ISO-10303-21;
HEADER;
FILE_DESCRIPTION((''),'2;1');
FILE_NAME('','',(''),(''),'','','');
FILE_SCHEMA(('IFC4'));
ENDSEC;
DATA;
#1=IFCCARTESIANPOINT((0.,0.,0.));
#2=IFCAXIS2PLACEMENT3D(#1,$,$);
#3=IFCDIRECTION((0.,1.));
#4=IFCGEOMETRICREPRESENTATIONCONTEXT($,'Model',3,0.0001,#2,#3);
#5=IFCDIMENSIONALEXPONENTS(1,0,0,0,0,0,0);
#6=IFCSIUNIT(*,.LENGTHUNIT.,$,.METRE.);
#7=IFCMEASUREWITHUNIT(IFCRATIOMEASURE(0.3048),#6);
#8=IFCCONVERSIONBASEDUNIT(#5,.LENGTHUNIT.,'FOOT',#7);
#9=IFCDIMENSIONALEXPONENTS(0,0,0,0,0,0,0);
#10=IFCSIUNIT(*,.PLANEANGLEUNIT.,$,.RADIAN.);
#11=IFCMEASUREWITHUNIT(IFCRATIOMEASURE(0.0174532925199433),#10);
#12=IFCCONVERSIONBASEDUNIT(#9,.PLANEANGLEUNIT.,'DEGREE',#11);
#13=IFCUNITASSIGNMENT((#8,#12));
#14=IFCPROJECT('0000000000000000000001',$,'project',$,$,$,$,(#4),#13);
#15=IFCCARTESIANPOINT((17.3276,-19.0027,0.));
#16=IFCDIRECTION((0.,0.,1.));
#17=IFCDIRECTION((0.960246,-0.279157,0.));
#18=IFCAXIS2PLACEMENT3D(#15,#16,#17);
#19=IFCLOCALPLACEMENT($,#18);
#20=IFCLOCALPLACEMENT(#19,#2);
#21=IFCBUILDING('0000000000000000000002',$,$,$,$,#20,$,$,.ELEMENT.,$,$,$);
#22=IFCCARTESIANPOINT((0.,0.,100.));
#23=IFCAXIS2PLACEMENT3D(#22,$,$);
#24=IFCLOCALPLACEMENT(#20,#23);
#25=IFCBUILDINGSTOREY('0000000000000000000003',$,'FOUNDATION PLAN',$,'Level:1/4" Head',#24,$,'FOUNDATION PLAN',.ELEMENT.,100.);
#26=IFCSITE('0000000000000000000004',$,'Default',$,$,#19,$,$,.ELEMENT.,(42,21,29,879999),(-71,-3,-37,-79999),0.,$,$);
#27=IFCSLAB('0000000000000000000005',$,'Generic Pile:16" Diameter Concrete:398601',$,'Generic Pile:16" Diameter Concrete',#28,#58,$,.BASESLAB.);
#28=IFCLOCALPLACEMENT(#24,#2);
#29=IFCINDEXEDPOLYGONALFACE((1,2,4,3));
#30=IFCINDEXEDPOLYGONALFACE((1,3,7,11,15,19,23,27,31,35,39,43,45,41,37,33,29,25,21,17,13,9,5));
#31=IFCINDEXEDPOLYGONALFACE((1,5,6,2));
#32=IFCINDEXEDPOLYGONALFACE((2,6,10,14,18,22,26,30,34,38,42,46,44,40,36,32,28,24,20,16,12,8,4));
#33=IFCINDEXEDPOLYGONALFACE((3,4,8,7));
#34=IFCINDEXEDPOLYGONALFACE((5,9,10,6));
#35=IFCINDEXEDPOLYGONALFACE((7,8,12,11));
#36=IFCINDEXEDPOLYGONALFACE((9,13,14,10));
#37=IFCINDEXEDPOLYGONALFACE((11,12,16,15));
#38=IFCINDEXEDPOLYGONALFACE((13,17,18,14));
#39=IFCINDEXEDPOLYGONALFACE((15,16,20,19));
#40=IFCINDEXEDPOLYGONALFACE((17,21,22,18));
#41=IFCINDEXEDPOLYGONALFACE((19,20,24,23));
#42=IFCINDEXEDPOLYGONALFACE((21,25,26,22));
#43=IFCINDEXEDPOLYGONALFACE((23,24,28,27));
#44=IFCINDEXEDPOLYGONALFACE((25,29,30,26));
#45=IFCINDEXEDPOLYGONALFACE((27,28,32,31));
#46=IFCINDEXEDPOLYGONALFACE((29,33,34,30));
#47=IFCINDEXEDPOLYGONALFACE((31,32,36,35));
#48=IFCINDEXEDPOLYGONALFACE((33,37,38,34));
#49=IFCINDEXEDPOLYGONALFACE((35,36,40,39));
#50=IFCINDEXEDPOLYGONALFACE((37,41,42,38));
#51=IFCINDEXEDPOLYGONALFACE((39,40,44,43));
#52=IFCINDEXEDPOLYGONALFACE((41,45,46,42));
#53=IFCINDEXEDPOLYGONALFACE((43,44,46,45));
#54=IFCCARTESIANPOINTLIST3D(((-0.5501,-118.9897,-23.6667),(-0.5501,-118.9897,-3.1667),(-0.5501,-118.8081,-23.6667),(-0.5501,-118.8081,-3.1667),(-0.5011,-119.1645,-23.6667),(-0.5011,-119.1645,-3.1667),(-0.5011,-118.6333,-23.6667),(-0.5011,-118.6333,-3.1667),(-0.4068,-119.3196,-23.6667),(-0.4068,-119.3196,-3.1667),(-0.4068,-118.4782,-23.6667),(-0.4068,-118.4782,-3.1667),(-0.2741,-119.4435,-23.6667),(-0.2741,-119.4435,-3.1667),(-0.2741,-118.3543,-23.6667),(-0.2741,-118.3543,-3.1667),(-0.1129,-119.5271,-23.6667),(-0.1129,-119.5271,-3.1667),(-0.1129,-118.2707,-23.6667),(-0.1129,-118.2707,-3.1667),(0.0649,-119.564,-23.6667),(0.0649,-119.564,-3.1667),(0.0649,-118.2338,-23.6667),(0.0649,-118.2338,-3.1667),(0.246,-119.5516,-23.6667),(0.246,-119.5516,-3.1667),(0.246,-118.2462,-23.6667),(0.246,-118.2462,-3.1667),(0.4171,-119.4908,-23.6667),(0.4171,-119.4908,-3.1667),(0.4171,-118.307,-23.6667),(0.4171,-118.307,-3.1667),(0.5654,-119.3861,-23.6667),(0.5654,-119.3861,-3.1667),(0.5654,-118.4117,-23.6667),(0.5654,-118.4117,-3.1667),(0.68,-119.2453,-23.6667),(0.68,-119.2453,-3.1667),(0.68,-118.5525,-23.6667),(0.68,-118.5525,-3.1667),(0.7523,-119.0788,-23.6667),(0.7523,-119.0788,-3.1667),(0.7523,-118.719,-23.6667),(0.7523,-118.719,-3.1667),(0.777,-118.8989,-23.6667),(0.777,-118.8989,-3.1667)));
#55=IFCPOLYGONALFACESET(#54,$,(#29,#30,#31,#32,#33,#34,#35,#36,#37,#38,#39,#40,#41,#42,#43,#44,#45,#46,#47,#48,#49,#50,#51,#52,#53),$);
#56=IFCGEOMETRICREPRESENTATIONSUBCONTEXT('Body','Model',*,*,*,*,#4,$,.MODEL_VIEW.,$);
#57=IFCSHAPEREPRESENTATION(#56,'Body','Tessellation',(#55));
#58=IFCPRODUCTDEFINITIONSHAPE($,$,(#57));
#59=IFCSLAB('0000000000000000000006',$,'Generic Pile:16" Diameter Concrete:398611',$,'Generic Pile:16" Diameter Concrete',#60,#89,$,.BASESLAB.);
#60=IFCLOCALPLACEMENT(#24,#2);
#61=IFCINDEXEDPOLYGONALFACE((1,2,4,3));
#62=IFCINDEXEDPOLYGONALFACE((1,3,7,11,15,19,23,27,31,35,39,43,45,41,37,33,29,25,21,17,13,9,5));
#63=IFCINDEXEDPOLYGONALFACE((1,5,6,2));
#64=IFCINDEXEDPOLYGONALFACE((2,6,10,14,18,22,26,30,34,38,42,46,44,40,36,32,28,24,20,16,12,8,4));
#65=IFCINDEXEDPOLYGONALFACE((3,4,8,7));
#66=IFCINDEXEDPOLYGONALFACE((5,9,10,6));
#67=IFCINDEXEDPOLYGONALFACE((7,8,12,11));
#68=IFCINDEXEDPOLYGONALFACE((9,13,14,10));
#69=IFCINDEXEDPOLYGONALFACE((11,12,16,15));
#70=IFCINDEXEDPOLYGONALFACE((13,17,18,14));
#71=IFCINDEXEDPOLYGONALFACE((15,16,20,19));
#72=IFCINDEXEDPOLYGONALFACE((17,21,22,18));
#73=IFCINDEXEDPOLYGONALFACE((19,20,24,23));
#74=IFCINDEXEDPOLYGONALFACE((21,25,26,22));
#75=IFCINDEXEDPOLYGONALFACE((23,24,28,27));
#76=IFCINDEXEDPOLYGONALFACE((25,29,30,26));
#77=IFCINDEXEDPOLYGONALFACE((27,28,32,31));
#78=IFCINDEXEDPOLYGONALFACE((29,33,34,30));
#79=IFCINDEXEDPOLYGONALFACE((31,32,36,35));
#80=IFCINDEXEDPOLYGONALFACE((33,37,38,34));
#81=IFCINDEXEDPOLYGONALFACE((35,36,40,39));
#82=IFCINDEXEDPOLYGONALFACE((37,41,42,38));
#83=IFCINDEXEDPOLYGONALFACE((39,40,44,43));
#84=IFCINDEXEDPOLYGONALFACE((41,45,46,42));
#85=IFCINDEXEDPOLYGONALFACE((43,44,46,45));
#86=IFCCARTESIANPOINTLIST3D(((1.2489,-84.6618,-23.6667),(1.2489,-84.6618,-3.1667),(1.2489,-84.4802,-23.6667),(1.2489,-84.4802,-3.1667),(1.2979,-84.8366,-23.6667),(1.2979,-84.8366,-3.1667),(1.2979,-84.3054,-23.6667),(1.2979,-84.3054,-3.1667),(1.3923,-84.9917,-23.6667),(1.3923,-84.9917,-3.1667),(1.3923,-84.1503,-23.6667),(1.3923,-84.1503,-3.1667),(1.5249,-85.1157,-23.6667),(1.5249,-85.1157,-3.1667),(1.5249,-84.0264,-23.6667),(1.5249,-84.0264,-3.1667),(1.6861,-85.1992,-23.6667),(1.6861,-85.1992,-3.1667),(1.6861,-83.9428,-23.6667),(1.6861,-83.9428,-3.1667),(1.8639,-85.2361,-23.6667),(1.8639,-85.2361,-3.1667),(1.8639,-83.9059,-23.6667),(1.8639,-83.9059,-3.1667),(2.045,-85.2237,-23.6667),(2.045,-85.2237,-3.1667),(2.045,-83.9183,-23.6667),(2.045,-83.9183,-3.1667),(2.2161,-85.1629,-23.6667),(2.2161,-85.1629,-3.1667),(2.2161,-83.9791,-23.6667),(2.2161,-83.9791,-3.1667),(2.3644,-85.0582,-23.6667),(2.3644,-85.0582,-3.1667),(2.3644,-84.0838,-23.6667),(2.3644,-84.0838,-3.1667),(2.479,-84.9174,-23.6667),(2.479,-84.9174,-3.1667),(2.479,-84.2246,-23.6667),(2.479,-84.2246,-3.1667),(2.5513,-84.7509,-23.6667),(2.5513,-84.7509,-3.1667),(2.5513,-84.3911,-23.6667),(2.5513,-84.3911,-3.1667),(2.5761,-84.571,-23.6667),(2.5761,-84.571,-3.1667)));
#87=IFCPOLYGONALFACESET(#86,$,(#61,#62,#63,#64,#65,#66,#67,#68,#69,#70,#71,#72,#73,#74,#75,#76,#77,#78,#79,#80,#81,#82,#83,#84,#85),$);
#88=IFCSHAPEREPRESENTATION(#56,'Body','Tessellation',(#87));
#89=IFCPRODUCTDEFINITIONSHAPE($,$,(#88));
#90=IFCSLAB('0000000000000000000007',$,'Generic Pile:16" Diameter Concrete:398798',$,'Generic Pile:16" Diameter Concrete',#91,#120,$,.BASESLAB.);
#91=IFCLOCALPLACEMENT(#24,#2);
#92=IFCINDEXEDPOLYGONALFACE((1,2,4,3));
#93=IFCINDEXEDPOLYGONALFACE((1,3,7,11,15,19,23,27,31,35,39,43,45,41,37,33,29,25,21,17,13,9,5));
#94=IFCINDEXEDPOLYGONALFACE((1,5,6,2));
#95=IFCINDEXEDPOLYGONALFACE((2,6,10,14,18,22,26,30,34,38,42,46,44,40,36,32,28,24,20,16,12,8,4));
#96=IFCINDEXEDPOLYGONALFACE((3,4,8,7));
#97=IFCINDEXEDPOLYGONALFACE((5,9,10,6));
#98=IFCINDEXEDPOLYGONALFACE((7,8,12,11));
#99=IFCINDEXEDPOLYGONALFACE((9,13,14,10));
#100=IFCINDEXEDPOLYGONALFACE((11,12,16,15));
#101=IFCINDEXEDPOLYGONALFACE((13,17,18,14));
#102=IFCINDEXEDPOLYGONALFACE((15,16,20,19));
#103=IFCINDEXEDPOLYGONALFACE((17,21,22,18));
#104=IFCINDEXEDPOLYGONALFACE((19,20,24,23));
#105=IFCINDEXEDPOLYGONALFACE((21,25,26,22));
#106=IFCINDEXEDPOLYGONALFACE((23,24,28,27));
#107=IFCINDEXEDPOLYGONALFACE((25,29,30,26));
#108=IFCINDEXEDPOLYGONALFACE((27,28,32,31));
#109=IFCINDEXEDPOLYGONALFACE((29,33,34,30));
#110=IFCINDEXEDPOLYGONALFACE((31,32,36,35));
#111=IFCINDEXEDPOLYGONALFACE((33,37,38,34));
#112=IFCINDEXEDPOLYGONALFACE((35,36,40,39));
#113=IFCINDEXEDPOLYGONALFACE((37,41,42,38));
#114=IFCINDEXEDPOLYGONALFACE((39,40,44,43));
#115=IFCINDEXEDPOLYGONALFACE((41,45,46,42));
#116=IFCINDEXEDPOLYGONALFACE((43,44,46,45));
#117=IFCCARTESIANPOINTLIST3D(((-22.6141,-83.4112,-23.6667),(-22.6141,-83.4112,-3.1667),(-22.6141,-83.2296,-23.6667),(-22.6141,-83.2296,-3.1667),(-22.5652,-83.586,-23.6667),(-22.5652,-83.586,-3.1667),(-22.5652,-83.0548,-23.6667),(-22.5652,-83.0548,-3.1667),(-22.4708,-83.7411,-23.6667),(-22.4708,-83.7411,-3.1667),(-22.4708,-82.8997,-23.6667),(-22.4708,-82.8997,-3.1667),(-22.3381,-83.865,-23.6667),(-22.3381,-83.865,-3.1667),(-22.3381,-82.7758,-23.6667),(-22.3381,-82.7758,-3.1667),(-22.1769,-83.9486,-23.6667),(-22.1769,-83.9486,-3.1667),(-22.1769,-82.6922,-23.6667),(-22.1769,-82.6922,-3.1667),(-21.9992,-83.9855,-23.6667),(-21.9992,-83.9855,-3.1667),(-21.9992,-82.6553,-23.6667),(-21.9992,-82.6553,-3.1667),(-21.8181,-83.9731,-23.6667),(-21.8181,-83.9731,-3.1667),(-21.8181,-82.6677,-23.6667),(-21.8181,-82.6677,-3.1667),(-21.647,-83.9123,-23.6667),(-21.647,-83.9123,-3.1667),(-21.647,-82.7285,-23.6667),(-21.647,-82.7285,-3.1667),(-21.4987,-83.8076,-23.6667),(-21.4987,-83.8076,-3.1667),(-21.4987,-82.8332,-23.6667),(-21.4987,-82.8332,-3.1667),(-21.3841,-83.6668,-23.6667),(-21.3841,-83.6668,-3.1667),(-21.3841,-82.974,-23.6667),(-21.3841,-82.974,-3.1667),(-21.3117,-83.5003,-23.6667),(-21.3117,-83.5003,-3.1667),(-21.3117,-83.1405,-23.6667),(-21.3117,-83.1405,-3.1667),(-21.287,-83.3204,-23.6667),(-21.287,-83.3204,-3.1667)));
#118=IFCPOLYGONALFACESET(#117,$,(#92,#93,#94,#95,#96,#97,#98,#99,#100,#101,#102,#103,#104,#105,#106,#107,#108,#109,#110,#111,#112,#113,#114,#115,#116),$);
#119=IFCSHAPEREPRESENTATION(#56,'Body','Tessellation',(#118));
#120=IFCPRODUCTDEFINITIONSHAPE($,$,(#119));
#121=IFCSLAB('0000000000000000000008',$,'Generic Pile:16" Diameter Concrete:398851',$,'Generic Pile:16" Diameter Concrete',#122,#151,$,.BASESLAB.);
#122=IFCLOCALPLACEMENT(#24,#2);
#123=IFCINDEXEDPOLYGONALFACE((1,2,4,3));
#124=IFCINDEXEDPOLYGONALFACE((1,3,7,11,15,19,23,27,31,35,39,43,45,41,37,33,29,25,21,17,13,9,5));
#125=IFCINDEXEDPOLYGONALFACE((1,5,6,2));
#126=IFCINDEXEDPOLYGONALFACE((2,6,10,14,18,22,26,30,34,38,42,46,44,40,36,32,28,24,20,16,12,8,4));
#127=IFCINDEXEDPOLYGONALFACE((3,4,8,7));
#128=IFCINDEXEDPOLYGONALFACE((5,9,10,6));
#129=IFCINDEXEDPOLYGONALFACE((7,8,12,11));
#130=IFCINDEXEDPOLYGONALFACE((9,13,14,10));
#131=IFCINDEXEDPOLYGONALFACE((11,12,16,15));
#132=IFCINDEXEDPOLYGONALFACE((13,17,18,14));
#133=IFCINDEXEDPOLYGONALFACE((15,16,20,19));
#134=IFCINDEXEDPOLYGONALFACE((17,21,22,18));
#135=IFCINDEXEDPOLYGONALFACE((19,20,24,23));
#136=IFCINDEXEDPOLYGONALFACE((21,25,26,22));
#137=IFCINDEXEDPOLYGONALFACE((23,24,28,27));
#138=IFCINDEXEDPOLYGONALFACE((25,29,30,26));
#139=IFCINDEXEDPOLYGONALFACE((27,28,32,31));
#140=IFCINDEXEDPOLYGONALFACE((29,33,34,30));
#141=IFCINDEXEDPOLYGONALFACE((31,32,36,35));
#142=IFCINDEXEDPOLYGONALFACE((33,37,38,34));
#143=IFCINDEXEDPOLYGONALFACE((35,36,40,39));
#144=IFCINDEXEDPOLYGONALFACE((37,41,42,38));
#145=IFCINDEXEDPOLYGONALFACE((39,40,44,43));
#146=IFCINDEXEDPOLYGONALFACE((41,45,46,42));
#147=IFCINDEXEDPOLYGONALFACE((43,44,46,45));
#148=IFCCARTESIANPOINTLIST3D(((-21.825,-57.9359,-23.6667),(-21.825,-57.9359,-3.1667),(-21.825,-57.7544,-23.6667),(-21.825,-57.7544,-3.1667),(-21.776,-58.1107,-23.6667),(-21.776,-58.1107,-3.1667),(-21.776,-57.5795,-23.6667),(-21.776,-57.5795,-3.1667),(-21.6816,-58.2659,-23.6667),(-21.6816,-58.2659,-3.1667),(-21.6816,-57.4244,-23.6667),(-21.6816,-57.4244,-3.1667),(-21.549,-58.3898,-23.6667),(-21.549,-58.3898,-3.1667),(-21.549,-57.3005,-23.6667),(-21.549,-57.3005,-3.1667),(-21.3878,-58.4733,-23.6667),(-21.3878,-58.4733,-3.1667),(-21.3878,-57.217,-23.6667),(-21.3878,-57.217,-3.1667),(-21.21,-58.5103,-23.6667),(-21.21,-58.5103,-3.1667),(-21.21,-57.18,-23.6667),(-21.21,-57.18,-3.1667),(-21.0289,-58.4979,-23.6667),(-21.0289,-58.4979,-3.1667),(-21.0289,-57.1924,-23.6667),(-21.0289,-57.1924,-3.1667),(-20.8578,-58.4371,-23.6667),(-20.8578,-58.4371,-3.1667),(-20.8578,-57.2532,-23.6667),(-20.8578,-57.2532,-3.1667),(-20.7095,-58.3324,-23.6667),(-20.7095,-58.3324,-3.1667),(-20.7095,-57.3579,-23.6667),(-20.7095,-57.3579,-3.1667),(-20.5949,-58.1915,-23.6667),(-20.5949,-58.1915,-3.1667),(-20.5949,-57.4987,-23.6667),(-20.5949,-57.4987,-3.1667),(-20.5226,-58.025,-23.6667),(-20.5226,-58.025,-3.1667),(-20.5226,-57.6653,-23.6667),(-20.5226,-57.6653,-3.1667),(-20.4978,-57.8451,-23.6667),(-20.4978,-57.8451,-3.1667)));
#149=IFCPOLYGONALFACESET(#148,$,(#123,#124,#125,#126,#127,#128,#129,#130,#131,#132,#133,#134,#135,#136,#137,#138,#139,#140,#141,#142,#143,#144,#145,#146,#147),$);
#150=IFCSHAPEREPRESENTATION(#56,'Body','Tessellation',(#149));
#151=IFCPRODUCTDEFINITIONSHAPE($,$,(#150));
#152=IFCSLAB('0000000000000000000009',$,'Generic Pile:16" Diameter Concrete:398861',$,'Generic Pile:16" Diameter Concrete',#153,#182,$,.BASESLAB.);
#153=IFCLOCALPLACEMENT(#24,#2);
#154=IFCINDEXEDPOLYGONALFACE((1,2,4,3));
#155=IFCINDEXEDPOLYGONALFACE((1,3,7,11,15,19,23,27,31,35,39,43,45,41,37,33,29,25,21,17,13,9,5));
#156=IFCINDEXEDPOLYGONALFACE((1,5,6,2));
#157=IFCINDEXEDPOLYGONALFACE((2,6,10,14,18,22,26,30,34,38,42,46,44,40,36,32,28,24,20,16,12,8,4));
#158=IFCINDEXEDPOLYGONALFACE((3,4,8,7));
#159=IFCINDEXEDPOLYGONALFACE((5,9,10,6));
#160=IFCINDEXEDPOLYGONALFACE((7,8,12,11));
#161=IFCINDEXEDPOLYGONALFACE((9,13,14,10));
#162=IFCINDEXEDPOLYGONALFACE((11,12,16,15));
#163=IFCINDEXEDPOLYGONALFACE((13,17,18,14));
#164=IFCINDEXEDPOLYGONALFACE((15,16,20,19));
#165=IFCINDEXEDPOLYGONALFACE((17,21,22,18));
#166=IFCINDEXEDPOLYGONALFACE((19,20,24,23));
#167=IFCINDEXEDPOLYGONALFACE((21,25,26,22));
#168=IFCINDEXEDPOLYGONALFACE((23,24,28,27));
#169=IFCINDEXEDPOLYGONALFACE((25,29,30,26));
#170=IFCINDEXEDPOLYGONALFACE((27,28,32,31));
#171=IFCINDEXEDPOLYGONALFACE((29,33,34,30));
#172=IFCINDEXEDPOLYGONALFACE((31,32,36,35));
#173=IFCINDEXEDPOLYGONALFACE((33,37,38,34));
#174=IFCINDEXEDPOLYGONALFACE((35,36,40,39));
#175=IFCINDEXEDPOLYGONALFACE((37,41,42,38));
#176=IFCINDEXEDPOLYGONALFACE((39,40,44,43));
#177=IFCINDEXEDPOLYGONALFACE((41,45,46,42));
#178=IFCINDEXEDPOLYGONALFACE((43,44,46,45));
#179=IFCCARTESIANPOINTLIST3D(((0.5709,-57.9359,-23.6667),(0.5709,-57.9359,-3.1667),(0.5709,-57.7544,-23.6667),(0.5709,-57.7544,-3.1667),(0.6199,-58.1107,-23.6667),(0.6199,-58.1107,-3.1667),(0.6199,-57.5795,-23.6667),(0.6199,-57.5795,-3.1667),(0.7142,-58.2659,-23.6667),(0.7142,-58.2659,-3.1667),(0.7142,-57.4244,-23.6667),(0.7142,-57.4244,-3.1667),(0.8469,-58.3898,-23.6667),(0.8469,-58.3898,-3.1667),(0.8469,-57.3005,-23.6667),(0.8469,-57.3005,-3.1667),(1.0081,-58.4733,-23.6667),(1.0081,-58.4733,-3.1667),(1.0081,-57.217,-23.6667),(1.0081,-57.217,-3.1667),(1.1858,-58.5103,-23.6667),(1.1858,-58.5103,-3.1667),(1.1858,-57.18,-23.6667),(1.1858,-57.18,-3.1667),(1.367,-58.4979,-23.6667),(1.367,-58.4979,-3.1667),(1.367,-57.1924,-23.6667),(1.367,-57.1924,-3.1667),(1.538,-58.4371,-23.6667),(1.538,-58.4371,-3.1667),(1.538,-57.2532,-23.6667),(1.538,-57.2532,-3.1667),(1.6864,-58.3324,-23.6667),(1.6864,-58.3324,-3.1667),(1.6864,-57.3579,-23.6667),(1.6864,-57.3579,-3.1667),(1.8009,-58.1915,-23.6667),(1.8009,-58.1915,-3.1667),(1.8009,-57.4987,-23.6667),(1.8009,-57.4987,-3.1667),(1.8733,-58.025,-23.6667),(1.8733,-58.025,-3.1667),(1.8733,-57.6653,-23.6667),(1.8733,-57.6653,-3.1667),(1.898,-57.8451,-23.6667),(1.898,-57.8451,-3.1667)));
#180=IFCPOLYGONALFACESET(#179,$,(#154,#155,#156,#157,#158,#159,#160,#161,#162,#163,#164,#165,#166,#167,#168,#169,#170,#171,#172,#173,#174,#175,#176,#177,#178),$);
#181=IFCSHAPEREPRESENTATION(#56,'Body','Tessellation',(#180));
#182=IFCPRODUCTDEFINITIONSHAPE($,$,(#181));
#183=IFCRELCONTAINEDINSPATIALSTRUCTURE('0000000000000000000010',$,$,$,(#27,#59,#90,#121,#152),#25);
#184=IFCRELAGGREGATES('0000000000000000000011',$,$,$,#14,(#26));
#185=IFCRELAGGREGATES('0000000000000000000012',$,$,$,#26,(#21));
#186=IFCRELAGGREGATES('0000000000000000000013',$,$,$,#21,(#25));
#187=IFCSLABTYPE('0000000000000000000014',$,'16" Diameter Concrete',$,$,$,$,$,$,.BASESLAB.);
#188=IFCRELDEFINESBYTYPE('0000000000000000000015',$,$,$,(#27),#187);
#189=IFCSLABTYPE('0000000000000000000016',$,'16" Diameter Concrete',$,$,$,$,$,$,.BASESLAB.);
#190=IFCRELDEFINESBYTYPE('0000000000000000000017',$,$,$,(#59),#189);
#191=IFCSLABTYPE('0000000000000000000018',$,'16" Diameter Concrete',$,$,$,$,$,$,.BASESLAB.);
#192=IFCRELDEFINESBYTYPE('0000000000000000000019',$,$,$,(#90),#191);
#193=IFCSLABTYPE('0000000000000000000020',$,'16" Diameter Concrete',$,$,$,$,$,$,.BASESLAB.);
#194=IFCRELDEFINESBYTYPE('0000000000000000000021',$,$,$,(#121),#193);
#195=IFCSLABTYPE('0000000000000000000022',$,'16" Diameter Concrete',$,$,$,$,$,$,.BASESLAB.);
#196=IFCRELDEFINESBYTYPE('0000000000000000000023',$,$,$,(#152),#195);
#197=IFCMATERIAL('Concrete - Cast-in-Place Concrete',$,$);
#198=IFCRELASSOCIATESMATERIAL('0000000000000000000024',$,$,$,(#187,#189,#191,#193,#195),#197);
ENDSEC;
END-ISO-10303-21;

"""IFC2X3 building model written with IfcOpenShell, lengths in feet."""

from ifc_helpers import new_model, entity, si_unit, converted_unit, direction, frame, frame_2d, origin, origin_2d_with_axis, place, context, subcontext, project, spatial, circle, extrude, material, type_object, element, save


model = new_model("IFC2X3")

# Units and contexts
model_context = context("Model", 3, precision=0.0001, world=origin(), true_north=direction((0.0, 1.0)))
body_context = subcontext(model_context, "Body", "Model", "MODEL_VIEW")
ifc_project = project(units=[converted_unit("LENGTHUNIT", "FOOT", entity("IfcRatioMeasure", 0.3048), si_unit("LENGTHUNIT", "METRE"), dimensions=[1, 0, 0, 0, 0, 0, 0]), converted_unit("PLANEANGLEUNIT", "DEGREE", entity("IfcRatioMeasure", 0.0174532925199433), si_unit("PLANEANGLEUNIT", "RADIAN"), dimensions=[0, 0, 0, 0, 0, 0, 0])], contexts=[model_context])

# Site, building, storey
site_placement = place(None, frame((17.3276, -19.0027, 0.0), z_axis=(0.0, 0.0, 1.0), x_axis=(0.960246, -0.279157, 0.0)))
site = spatial("IfcSite", under=ifc_project, at=site_placement, Name="Default", CompositionType="ELEMENT", RefLatitude=(42, 21, 29, 879999), RefLongitude=(-71, -3, -37, -79999), RefElevation=0.0)
building_placement = place(site_placement, origin())
building = spatial("IfcBuilding", under=site, at=building_placement, CompositionType="ELEMENT")
storey_placement = place(building_placement, frame((0.0, 0.0, 100.0)))
storey = spatial("IfcBuildingStorey", under=building, at=storey_placement, Name="FOUNDATION PLAN", ObjectType="Level:1/4\" Head", LongName="FOUNDATION PLAN", CompositionType="ELEMENT", Elevation=100.0)

# Slabs
ifc_material_1 = material(Name="Concrete - Cast-in-Place Concrete")
slab_type_1 = type_object("IfcSlabType", Name="16\" Diameter Concrete", PredefinedType="BASESLAB", material=ifc_material_1)
slab_1_placement = place(storey_placement, origin())
element("IfcSlab", 1, at=slab_1_placement, inside=storey, type_object=slab_type_1, Name="Generic Pile:16\" Diameter Concrete:398601", ObjectType="Generic Pile:16\" Diameter Concrete", PredefinedType="BASESLAB", context=body_context, shape_type="SweptSolid", body=[
    extrude(circle(Radius=0.6667, at=frame_2d((0.0, 0.0), x_axis=(1.0, 0.0))), frame((0.1103, -118.8989, -23.6667)), (0.0, 0.0, 1.0), 20.5),
])
slab_type_2 = type_object("IfcSlabType", Name="16\" Diameter Concrete", PredefinedType="BASESLAB", material=ifc_material_1)
slab_2_placement = place(storey_placement, origin())
element("IfcSlab", 2, at=slab_2_placement, inside=storey, type_object=slab_type_2, Name="Generic Pile:16\" Diameter Concrete:398611", ObjectType="Generic Pile:16\" Diameter Concrete", PredefinedType="BASESLAB", context=body_context, shape_type="SweptSolid", body=[
    extrude(circle(Radius=0.6667, at=origin_2d_with_axis()), frame((1.9094, -84.571, -23.6667)), (0.0, 0.0, 1.0), 20.5),
])
slab_type_3 = type_object("IfcSlabType", Name="16\" Diameter Concrete", PredefinedType="BASESLAB", material=ifc_material_1)
slab_3_placement = place(storey_placement, origin())
element("IfcSlab", 3, at=slab_3_placement, inside=storey, type_object=slab_type_3, Name="Generic Pile:16\" Diameter Concrete:398798", ObjectType="Generic Pile:16\" Diameter Concrete", PredefinedType="BASESLAB", context=body_context, shape_type="SweptSolid", body=[
    extrude(circle(Radius=0.6667, at=origin_2d_with_axis()), frame((-21.9537, -83.3204, -23.6667)), (0.0, 0.0, 1.0), 20.5),
])
slab_type_4 = type_object("IfcSlabType", Name="16\" Diameter Concrete", PredefinedType="BASESLAB", material=ifc_material_1)
slab_4_placement = place(storey_placement, origin())
element("IfcSlab", 4, at=slab_4_placement, inside=storey, type_object=slab_type_4, Name="Generic Pile:16\" Diameter Concrete:398851", ObjectType="Generic Pile:16\" Diameter Concrete", PredefinedType="BASESLAB", context=body_context, shape_type="SweptSolid", body=[
    extrude(circle(Radius=0.6667, at=origin_2d_with_axis()), frame((-21.1645, -57.8451, -23.6667)), (0.0, 0.0, 1.0), 20.5),
])
slab_type_5 = type_object("IfcSlabType", Name="16\" Diameter Concrete", PredefinedType="BASESLAB", material=ifc_material_1)
slab_5_placement = place(storey_placement, origin())
element("IfcSlab", 5, at=slab_5_placement, inside=storey, type_object=slab_type_5, Name="Generic Pile:16\" Diameter Concrete:398861", ObjectType="Generic Pile:16\" Diameter Concrete", PredefinedType="BASESLAB", context=body_context, shape_type="SweptSolid", body=[
    extrude(circle(Radius=0.6667, at=origin_2d_with_axis()), frame((1.2313, -57.8451, -23.6667)), (0.0, 0.0, 1.0), 20.5),
])

save(model, "model.ifc")
